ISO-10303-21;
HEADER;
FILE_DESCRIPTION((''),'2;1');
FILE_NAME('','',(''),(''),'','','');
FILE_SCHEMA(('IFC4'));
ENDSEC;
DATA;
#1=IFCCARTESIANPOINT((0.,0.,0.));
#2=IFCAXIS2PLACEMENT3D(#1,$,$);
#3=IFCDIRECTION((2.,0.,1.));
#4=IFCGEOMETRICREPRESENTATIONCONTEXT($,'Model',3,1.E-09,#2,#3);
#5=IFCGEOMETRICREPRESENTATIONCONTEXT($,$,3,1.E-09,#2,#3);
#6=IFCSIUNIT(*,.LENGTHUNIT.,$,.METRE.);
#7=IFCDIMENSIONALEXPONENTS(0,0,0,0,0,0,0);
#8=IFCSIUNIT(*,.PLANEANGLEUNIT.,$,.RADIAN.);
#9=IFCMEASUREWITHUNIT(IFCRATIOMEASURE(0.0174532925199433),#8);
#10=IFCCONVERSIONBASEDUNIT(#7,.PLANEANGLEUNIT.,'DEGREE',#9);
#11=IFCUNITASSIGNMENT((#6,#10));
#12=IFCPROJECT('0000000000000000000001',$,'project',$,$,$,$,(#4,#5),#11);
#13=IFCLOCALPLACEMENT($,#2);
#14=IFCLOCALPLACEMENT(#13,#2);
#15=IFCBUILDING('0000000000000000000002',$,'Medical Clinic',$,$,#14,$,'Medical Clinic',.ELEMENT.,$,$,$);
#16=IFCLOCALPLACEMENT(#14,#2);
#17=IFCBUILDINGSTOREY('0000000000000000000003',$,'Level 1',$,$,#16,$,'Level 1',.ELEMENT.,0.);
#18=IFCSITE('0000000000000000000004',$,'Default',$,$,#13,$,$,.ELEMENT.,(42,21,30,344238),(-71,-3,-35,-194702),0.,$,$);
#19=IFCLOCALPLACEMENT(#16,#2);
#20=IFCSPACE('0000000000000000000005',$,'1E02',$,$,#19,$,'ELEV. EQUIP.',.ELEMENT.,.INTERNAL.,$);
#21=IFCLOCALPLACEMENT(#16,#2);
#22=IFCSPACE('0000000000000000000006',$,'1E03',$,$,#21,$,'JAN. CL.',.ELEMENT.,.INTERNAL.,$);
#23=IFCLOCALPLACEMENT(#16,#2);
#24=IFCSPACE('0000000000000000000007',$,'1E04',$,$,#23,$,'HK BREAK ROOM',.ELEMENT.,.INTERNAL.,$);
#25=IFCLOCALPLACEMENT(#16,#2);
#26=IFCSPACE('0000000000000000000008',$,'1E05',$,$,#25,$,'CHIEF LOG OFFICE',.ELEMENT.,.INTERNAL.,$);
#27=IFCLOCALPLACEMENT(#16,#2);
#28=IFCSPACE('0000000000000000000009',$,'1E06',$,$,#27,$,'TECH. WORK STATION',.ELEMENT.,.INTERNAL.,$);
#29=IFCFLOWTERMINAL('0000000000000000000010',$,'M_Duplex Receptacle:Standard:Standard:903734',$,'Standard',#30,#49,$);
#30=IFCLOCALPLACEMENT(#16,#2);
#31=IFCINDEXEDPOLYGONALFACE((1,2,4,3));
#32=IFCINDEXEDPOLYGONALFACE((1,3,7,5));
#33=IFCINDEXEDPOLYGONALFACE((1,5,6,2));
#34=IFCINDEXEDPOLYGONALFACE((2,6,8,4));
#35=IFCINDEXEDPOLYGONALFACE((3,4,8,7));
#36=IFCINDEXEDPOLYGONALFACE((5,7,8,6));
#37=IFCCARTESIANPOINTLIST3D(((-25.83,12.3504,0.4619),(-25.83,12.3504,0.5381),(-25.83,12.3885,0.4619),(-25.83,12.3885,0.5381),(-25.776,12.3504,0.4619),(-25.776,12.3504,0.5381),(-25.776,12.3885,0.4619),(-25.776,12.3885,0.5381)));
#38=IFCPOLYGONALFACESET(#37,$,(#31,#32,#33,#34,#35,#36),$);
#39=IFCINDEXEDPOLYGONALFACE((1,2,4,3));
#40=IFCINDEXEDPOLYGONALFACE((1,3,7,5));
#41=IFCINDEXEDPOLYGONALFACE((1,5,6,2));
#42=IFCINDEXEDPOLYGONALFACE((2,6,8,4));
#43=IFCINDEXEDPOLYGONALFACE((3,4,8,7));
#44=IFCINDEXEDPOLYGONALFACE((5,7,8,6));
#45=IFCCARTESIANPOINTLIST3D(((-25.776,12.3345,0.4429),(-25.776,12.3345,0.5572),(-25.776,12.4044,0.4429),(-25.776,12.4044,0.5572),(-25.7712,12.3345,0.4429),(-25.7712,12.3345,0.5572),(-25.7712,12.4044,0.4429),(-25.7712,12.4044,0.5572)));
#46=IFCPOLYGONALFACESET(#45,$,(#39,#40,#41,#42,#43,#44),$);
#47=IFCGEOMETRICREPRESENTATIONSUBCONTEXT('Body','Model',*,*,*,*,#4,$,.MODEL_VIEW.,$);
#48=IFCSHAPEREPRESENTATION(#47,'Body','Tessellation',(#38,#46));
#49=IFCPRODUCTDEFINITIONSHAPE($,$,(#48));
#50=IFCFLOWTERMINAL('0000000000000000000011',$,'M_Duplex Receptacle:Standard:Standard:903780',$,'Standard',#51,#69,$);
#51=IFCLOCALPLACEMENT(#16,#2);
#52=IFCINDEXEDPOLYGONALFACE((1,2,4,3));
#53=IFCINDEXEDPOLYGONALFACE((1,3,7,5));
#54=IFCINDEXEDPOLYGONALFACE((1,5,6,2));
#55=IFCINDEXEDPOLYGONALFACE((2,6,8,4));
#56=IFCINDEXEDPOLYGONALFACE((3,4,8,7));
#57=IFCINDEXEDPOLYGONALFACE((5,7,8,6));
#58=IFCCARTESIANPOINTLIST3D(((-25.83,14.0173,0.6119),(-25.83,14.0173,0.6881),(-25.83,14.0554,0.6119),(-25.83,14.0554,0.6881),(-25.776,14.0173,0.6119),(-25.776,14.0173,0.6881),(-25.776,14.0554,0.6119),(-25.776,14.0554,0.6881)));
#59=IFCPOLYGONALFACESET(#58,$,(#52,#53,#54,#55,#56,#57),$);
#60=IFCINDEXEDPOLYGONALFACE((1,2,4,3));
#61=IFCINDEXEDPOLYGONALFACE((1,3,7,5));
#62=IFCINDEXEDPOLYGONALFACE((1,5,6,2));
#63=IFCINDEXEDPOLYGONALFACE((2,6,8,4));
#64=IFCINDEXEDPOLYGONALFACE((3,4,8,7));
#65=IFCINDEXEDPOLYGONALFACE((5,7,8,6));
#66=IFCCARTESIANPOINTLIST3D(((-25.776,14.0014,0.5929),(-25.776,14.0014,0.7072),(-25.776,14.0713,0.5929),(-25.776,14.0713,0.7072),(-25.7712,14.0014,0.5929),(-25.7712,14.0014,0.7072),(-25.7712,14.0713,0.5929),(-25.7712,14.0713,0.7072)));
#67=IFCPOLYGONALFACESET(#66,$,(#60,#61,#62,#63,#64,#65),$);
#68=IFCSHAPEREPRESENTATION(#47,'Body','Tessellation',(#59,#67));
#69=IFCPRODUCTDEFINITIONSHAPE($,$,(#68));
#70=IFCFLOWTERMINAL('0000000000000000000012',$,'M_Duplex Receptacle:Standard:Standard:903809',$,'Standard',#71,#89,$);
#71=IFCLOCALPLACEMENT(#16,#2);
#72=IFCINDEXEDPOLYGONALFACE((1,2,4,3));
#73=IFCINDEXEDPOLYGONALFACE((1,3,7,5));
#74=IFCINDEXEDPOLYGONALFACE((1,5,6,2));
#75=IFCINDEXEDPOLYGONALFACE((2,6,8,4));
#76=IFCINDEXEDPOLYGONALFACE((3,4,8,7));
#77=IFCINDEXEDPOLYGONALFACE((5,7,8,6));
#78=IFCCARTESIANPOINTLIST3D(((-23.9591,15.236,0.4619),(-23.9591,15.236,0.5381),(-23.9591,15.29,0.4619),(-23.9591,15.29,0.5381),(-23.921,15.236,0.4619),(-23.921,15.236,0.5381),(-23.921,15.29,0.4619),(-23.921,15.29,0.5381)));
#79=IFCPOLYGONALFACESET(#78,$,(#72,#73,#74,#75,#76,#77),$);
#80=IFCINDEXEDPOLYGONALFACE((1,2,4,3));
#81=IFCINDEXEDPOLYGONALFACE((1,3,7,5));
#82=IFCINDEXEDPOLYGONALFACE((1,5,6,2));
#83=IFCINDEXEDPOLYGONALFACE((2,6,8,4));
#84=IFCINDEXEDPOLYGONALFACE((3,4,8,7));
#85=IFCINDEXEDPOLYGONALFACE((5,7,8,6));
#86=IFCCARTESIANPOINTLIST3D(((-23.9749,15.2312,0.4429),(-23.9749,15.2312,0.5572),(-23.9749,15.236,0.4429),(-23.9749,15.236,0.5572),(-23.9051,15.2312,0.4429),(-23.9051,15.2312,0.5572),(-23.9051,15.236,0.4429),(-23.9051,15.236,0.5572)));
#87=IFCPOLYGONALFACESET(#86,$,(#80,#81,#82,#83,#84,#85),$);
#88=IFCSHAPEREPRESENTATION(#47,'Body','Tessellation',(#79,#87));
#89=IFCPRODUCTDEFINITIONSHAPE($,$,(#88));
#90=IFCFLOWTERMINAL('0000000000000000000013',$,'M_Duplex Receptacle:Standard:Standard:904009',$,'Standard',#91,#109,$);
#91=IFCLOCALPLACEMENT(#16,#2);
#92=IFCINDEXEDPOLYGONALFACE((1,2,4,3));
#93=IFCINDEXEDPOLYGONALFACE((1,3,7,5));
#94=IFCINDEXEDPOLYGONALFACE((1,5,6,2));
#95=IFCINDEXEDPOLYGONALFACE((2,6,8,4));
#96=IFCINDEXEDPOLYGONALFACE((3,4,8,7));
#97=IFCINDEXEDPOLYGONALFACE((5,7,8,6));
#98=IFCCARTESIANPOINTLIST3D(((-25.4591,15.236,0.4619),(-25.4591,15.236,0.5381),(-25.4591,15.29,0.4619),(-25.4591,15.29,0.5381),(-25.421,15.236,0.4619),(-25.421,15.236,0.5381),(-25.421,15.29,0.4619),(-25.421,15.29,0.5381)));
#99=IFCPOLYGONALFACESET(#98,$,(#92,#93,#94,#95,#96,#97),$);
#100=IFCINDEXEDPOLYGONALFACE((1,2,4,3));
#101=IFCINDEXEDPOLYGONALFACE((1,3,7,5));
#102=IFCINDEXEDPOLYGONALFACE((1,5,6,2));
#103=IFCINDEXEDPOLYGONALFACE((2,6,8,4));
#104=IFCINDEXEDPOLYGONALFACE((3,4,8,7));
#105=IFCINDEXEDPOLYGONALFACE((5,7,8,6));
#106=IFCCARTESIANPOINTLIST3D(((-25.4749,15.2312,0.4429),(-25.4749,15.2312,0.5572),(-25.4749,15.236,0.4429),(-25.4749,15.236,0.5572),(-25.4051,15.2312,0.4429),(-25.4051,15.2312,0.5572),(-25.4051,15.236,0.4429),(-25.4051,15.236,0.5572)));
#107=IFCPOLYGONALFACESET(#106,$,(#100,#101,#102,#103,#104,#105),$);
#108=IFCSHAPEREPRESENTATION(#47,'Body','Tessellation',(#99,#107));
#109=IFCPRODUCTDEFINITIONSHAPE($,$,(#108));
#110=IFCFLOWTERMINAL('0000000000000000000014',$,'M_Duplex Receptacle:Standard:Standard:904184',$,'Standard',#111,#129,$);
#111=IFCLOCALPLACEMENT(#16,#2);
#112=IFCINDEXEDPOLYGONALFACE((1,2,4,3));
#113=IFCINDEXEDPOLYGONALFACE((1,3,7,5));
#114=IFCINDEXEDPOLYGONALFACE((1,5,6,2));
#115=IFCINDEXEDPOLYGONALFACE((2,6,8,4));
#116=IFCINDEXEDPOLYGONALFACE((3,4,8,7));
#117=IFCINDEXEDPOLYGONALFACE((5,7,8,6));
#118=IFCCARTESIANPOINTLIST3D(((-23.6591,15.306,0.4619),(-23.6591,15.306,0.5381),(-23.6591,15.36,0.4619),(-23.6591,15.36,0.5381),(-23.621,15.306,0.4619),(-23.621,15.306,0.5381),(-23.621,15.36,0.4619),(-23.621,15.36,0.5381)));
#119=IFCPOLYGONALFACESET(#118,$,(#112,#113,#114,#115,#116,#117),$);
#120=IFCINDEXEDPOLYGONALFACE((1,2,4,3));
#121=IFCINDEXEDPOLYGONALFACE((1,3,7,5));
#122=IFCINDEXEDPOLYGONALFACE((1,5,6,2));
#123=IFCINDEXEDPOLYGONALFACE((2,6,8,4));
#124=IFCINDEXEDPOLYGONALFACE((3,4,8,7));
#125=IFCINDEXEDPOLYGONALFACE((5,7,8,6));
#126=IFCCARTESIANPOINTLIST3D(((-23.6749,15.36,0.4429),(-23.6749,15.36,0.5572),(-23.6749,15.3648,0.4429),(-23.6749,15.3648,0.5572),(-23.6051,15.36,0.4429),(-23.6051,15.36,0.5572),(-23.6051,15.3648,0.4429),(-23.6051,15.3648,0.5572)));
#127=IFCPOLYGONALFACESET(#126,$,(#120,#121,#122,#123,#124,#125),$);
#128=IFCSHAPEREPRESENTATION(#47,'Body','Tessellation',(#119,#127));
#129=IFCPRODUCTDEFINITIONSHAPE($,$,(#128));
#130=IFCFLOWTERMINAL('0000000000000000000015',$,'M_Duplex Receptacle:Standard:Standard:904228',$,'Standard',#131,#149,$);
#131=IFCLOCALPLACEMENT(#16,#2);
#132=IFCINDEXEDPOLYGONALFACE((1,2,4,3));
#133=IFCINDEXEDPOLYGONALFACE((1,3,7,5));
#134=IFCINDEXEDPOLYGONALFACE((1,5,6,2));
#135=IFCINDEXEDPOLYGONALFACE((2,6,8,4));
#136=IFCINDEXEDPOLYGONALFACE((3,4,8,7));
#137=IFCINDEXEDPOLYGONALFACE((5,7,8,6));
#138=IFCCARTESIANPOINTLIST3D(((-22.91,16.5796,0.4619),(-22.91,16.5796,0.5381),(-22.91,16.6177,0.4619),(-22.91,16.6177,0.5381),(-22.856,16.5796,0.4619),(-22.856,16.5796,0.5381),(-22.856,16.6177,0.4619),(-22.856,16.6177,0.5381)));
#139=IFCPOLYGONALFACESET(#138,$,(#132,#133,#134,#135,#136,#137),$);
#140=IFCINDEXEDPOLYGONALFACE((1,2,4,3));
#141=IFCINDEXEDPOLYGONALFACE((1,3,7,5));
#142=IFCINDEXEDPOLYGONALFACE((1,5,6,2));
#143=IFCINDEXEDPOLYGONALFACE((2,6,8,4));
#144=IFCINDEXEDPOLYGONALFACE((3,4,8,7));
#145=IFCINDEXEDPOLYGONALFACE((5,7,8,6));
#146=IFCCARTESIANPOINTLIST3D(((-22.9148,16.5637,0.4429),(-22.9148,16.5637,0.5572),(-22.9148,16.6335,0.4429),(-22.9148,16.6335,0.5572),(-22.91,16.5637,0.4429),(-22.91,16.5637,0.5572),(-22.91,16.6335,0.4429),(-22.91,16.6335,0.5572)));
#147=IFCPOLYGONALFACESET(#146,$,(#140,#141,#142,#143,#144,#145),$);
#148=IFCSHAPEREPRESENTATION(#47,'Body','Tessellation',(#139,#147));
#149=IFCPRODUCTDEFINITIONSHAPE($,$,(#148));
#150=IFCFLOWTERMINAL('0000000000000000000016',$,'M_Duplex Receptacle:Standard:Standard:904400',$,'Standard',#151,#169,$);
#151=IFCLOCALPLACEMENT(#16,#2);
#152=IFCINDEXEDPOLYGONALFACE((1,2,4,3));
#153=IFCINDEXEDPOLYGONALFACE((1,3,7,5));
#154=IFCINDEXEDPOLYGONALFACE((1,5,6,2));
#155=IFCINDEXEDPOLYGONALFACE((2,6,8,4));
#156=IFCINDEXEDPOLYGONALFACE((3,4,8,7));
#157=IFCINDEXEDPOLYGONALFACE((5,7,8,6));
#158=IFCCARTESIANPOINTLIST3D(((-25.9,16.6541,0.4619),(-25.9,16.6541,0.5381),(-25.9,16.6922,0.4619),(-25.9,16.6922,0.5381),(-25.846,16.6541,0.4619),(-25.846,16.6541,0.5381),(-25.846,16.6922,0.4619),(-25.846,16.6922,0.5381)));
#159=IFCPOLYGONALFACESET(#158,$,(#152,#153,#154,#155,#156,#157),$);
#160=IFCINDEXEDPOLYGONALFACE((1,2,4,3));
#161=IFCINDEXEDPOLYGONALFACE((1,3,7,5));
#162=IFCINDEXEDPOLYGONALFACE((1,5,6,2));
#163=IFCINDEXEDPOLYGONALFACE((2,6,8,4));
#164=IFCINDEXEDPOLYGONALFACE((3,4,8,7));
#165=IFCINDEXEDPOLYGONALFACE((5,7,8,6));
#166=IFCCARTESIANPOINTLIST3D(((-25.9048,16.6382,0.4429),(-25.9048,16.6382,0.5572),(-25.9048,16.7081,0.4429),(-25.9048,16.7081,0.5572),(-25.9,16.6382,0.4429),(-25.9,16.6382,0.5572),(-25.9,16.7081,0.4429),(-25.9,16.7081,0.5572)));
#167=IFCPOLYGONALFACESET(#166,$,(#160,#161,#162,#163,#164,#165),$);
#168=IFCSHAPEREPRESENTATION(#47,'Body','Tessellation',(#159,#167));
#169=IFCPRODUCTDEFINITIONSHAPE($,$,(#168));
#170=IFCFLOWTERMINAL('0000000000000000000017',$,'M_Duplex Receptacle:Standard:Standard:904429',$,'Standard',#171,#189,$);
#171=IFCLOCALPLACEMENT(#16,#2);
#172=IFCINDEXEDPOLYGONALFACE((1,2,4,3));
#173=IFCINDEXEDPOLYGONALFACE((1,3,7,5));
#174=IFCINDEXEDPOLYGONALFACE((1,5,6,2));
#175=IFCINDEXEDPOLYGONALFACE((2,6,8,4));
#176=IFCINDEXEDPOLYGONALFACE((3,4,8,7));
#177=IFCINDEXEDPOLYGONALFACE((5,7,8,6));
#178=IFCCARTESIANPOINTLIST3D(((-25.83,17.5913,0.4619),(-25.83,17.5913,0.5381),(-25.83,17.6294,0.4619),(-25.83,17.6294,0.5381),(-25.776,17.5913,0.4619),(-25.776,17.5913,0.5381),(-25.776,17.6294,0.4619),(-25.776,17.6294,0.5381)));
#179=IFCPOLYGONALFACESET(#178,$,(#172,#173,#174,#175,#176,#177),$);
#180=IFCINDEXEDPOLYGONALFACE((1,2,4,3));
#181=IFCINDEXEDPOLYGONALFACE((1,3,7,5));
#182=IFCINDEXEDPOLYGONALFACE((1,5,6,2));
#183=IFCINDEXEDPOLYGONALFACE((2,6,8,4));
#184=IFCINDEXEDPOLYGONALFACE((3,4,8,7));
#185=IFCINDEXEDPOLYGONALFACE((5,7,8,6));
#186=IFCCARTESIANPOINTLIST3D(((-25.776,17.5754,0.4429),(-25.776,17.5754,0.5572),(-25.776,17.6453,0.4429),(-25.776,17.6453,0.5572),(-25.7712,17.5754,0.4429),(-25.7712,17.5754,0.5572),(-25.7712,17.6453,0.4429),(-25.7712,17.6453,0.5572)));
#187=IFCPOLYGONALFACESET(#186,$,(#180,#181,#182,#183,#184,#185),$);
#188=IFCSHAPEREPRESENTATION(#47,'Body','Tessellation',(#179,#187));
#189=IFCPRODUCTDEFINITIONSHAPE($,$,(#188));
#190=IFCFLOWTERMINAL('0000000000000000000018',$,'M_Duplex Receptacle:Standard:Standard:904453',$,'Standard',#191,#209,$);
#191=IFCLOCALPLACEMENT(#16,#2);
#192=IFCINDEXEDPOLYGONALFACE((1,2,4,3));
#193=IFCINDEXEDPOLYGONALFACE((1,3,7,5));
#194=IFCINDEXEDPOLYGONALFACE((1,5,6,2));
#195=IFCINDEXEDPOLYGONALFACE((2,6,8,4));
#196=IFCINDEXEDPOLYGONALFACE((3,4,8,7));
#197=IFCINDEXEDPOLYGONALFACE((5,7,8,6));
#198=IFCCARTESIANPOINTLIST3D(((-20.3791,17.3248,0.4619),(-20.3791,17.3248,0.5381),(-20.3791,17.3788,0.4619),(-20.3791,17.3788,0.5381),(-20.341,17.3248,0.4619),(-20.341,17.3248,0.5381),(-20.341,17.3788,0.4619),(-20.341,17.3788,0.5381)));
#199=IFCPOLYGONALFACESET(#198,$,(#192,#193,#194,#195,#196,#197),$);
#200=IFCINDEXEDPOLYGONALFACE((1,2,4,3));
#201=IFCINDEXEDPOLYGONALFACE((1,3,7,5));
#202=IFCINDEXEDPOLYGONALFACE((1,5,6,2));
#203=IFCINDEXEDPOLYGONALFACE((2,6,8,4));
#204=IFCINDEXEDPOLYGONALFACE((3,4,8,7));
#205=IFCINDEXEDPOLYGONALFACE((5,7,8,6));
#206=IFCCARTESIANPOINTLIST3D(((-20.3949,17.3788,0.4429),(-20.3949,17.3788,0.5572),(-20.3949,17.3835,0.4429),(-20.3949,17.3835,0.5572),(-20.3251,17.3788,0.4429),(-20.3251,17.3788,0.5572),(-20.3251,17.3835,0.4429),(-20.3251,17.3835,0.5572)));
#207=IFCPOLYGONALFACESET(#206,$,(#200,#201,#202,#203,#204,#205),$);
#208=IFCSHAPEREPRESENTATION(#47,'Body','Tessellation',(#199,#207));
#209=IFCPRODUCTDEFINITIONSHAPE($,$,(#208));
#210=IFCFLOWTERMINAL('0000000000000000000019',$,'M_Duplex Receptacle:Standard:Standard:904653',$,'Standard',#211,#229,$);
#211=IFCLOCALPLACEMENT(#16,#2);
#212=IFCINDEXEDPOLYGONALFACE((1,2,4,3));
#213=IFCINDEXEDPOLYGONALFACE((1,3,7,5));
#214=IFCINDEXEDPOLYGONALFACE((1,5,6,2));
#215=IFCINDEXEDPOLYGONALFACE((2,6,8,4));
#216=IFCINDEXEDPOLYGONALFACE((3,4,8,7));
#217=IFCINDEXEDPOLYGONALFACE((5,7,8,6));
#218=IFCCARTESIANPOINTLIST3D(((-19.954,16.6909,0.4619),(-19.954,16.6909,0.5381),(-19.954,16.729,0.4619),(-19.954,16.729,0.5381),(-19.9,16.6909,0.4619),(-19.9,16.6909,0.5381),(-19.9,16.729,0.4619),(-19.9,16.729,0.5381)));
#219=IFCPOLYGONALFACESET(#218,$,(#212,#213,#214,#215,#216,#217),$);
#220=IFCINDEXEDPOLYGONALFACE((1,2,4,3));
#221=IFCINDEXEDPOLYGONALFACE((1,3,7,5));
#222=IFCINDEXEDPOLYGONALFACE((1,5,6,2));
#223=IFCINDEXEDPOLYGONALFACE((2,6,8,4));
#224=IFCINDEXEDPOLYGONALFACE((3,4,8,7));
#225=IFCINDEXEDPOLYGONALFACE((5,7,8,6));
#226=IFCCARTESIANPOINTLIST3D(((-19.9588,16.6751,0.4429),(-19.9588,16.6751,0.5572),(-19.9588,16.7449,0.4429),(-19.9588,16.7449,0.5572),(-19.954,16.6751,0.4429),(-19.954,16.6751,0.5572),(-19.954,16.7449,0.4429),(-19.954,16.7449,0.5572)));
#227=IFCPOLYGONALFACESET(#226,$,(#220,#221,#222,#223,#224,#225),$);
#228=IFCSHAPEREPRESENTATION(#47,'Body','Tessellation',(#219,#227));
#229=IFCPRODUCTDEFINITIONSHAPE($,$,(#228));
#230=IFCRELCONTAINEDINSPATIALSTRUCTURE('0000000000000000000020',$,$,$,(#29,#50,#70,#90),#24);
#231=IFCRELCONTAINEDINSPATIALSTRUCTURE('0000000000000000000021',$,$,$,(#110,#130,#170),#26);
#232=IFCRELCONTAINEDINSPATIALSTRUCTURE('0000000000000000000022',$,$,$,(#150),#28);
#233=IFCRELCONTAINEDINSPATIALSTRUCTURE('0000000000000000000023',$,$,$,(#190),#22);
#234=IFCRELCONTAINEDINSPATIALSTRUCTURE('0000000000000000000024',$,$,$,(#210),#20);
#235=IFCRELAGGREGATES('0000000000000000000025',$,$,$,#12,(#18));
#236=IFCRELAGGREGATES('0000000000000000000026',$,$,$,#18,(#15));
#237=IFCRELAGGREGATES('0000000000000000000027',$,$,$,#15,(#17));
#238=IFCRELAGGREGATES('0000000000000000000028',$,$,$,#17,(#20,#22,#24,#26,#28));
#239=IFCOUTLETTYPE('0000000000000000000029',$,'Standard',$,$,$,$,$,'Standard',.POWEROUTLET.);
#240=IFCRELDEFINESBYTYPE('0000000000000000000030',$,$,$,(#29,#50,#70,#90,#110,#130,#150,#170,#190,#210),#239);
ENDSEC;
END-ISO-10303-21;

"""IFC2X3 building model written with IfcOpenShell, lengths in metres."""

from ifc_helpers import new_model, entity, si_unit, converted_unit, direction, frame, frame_2d, origin, origin_2d_with_axis, place, context, subcontext, project, spatial, rectangle, extrude, source, transform, mapped, type_object, type_shapes, element, save


model = new_model("IFC2X3")

# Units and contexts
model_context = context("Model", 3, precision=1e-09, world=origin(), true_north=direction((2.0, 0.0, 1.0)))
context_of_model = context(None, 3, precision=1e-09, world=origin(), true_north=direction((2.0, 0.0, 1.0)))
body_context = subcontext(model_context, "Body", "Model", "MODEL_VIEW")
ifc_project = project(units=[si_unit("LENGTHUNIT", "METRE"), converted_unit("PLANEANGLEUNIT", "DEGREE", entity("IfcRatioMeasure", 0.0174532925199433), si_unit("PLANEANGLEUNIT", "RADIAN"), dimensions=[0, 0, 0, 0, 0, 0, 0])], contexts=[model_context, context_of_model])

# Site, building, storey
site_placement = place(None, origin())
site = spatial("IfcSite", under=ifc_project, at=site_placement, Name="Default", CompositionType="ELEMENT", RefLatitude=(42, 21, 30, 344238), RefLongitude=(-71, -3, -35, -194702), RefElevation=0.0)
building_placement = place(site_placement, origin())
building = spatial("IfcBuilding", under=site, at=building_placement, Name="Medical Clinic", LongName="Medical Clinic", CompositionType="ELEMENT")
storey_placement = place(building_placement, origin())
storey = spatial("IfcBuildingStorey", under=building, at=storey_placement, Name="Level 1", LongName="Level 1", CompositionType="ELEMENT", Elevation=0.0)

# Shared definitions
space_1_placement = place(storey_placement, origin())
space_1 = spatial("IfcSpace", under=storey, at=space_1_placement, Name="1E02", LongName="ELEV. EQUIP.", CompositionType="ELEMENT", InteriorOrExteriorSpace="INTERNAL")

# Shared definitions
space_2_placement = place(storey_placement, origin())
space_2 = spatial("IfcSpace", under=storey, at=space_2_placement, Name="1E03", LongName="JAN. CL.", CompositionType="ELEMENT", InteriorOrExteriorSpace="INTERNAL")

# Shared definitions
space_3_placement = place(storey_placement, origin())
space_3 = spatial("IfcSpace", under=storey, at=space_3_placement, Name="1E04", LongName="HK BREAK ROOM", CompositionType="ELEMENT", InteriorOrExteriorSpace="INTERNAL")

# Shared definitions
space_4_placement = place(storey_placement, origin())
space_4 = spatial("IfcSpace", under=storey, at=space_4_placement, Name="1E05", LongName="CHIEF LOG OFFICE", CompositionType="ELEMENT", InteriorOrExteriorSpace="INTERNAL")

# Shared definitions
outlet_type = type_object("IfcOutletType", Name="Standard", ElementType="Standard", PredefinedType="POWEROUTLET")
shared_shape_1 = source(origin(), body_context, "Body", "SweptSolid", [
    extrude(rectangle(XDim=0.0381, YDim=0.0762, at=origin_2d_with_axis()), frame((0.0, 0.0, -0.054), z_axis=(0.0, 0.0, 1.0), x_axis=(-1.0, 0.0, 0.0)), (0.0, 0.0, 1.0), 0.054),
    extrude(rectangle(XDim=0.0698, YDim=0.1143, at=frame_2d((0.0, 0.0), x_axis=(1.0, 0.0))), frame((0.0, 0.0, 0.0), z_axis=(0.0, 0.0, 1.0), x_axis=(-1.0, 0.0, 0.0)), (0.0, 0.0, 1.0), 0.0048),
])
type_shapes(outlet_type, [shared_shape_1])

# Shared definitions
space_5_placement = place(storey_placement, origin())
space_5 = spatial("IfcSpace", under=storey, at=space_5_placement, Name="1E06", LongName="TECH. WORK STATION", CompositionType="ELEMENT", InteriorOrExteriorSpace="INTERNAL")

# Flow terminals
for number, where, z_axis, x_axis, name in (
    (1, (-25.776, 12.3694, 0.5), (1.0, 0.0, 0.0), (0.0, 1.0, 0.0), "M_Duplex Receptacle:Standard:Standard:903734"),
    (2, (-25.776, 14.0363, 0.65), (1.0, 0.0, 0.0), (0.0, 1.0, 0.0), "M_Duplex Receptacle:Standard:Standard:903780"),
    (3, (-23.94, 15.236, 0.5), (0.0, -1.0, 0.0), (1.0, 0.0, 0.0), "M_Duplex Receptacle:Standard:Standard:903809"),
    (4, (-25.44, 15.236, 0.5), (0.0, -1.0, 0.0), (1.0, 0.0, 0.0), "M_Duplex Receptacle:Standard:Standard:904009"),
):
    element("IfcFlowTerminal", number, at=place(space_3_placement, frame(where, z_axis=z_axis, x_axis=x_axis)), inside=space_3, type_object=outlet_type, Name=name, ObjectType="Standard", context=body_context, shape_type="MappedRepresentation", body=[
        mapped(shared_shape_1, transform((0.0, 0.0, 0.0), scale=1.0)),
    ])
for number, where, z_axis, x_axis, name in (
    (5, (-23.64, 15.36, 0.5), (0.0, 1.0, 0.0), (-1.0, 0.0, 0.0), "M_Duplex Receptacle:Standard:Standard:904184"),
    (6, (-22.91, 16.5986, 0.5), (-1.0, 0.0, 0.0), (0.0, -1.0, 0.0), "M_Duplex Receptacle:Standard:Standard:904228"),
):
    element("IfcFlowTerminal", number, at=place(space_4_placement, frame(where, z_axis=z_axis, x_axis=x_axis)), inside=space_4, type_object=outlet_type, Name=name, ObjectType="Standard", context=body_context, shape_type="MappedRepresentation", body=[
        mapped(shared_shape_1, transform((0.0, 0.0, 0.0), scale=1.0)),
    ])
flow_terminal_1_placement = place(space_5_placement, frame((-25.9, 16.6732, 0.5), z_axis=(-1.0, 0.0, 0.0), x_axis=(0.0, -1.0, 0.0)))
element("IfcFlowTerminal", 7, at=flow_terminal_1_placement, inside=space_5, type_object=outlet_type, Name="M_Duplex Receptacle:Standard:Standard:904400", ObjectType="Standard", context=body_context, shape_type="MappedRepresentation", body=[
    mapped(shared_shape_1, transform((0.0, 0.0, 0.0), scale=1.0)),
])
flow_terminal_2_placement = place(space_4_placement, frame((-25.776, 17.6103, 0.5), z_axis=(1.0, 0.0, 0.0), x_axis=(0.0, 1.0, 0.0)))
element("IfcFlowTerminal", 8, at=flow_terminal_2_placement, inside=space_4, type_object=outlet_type, Name="M_Duplex Receptacle:Standard:Standard:904429", ObjectType="Standard", context=body_context, shape_type="MappedRepresentation", body=[
    mapped(shared_shape_1, transform((0.0, 0.0, 0.0), scale=1.0)),
])
flow_terminal_3_placement = place(space_2_placement, frame((-20.36, 17.3788, 0.5), z_axis=(0.0, 1.0, 0.0), x_axis=(-1.0, 0.0, 0.0)))
element("IfcFlowTerminal", 9, at=flow_terminal_3_placement, inside=space_2, type_object=outlet_type, Name="M_Duplex Receptacle:Standard:Standard:904453", ObjectType="Standard", context=body_context, shape_type="MappedRepresentation", body=[
    mapped(shared_shape_1, transform((0.0, 0.0, 0.0), scale=1.0)),
])
flow_terminal_4_placement = place(space_1_placement, frame((-19.954, 16.71, 0.5), z_axis=(-1.0, 0.0, 0.0), x_axis=(0.0, -1.0, 0.0)))
element("IfcFlowTerminal", 10, at=flow_terminal_4_placement, inside=space_1, type_object=outlet_type, Name="M_Duplex Receptacle:Standard:Standard:904653", ObjectType="Standard", context=body_context, shape_type="MappedRepresentation", body=[
    mapped(shared_shape_1, transform((0.0, 0.0, 0.0), scale=1.0)),
])

save(model, "model.ifc")
